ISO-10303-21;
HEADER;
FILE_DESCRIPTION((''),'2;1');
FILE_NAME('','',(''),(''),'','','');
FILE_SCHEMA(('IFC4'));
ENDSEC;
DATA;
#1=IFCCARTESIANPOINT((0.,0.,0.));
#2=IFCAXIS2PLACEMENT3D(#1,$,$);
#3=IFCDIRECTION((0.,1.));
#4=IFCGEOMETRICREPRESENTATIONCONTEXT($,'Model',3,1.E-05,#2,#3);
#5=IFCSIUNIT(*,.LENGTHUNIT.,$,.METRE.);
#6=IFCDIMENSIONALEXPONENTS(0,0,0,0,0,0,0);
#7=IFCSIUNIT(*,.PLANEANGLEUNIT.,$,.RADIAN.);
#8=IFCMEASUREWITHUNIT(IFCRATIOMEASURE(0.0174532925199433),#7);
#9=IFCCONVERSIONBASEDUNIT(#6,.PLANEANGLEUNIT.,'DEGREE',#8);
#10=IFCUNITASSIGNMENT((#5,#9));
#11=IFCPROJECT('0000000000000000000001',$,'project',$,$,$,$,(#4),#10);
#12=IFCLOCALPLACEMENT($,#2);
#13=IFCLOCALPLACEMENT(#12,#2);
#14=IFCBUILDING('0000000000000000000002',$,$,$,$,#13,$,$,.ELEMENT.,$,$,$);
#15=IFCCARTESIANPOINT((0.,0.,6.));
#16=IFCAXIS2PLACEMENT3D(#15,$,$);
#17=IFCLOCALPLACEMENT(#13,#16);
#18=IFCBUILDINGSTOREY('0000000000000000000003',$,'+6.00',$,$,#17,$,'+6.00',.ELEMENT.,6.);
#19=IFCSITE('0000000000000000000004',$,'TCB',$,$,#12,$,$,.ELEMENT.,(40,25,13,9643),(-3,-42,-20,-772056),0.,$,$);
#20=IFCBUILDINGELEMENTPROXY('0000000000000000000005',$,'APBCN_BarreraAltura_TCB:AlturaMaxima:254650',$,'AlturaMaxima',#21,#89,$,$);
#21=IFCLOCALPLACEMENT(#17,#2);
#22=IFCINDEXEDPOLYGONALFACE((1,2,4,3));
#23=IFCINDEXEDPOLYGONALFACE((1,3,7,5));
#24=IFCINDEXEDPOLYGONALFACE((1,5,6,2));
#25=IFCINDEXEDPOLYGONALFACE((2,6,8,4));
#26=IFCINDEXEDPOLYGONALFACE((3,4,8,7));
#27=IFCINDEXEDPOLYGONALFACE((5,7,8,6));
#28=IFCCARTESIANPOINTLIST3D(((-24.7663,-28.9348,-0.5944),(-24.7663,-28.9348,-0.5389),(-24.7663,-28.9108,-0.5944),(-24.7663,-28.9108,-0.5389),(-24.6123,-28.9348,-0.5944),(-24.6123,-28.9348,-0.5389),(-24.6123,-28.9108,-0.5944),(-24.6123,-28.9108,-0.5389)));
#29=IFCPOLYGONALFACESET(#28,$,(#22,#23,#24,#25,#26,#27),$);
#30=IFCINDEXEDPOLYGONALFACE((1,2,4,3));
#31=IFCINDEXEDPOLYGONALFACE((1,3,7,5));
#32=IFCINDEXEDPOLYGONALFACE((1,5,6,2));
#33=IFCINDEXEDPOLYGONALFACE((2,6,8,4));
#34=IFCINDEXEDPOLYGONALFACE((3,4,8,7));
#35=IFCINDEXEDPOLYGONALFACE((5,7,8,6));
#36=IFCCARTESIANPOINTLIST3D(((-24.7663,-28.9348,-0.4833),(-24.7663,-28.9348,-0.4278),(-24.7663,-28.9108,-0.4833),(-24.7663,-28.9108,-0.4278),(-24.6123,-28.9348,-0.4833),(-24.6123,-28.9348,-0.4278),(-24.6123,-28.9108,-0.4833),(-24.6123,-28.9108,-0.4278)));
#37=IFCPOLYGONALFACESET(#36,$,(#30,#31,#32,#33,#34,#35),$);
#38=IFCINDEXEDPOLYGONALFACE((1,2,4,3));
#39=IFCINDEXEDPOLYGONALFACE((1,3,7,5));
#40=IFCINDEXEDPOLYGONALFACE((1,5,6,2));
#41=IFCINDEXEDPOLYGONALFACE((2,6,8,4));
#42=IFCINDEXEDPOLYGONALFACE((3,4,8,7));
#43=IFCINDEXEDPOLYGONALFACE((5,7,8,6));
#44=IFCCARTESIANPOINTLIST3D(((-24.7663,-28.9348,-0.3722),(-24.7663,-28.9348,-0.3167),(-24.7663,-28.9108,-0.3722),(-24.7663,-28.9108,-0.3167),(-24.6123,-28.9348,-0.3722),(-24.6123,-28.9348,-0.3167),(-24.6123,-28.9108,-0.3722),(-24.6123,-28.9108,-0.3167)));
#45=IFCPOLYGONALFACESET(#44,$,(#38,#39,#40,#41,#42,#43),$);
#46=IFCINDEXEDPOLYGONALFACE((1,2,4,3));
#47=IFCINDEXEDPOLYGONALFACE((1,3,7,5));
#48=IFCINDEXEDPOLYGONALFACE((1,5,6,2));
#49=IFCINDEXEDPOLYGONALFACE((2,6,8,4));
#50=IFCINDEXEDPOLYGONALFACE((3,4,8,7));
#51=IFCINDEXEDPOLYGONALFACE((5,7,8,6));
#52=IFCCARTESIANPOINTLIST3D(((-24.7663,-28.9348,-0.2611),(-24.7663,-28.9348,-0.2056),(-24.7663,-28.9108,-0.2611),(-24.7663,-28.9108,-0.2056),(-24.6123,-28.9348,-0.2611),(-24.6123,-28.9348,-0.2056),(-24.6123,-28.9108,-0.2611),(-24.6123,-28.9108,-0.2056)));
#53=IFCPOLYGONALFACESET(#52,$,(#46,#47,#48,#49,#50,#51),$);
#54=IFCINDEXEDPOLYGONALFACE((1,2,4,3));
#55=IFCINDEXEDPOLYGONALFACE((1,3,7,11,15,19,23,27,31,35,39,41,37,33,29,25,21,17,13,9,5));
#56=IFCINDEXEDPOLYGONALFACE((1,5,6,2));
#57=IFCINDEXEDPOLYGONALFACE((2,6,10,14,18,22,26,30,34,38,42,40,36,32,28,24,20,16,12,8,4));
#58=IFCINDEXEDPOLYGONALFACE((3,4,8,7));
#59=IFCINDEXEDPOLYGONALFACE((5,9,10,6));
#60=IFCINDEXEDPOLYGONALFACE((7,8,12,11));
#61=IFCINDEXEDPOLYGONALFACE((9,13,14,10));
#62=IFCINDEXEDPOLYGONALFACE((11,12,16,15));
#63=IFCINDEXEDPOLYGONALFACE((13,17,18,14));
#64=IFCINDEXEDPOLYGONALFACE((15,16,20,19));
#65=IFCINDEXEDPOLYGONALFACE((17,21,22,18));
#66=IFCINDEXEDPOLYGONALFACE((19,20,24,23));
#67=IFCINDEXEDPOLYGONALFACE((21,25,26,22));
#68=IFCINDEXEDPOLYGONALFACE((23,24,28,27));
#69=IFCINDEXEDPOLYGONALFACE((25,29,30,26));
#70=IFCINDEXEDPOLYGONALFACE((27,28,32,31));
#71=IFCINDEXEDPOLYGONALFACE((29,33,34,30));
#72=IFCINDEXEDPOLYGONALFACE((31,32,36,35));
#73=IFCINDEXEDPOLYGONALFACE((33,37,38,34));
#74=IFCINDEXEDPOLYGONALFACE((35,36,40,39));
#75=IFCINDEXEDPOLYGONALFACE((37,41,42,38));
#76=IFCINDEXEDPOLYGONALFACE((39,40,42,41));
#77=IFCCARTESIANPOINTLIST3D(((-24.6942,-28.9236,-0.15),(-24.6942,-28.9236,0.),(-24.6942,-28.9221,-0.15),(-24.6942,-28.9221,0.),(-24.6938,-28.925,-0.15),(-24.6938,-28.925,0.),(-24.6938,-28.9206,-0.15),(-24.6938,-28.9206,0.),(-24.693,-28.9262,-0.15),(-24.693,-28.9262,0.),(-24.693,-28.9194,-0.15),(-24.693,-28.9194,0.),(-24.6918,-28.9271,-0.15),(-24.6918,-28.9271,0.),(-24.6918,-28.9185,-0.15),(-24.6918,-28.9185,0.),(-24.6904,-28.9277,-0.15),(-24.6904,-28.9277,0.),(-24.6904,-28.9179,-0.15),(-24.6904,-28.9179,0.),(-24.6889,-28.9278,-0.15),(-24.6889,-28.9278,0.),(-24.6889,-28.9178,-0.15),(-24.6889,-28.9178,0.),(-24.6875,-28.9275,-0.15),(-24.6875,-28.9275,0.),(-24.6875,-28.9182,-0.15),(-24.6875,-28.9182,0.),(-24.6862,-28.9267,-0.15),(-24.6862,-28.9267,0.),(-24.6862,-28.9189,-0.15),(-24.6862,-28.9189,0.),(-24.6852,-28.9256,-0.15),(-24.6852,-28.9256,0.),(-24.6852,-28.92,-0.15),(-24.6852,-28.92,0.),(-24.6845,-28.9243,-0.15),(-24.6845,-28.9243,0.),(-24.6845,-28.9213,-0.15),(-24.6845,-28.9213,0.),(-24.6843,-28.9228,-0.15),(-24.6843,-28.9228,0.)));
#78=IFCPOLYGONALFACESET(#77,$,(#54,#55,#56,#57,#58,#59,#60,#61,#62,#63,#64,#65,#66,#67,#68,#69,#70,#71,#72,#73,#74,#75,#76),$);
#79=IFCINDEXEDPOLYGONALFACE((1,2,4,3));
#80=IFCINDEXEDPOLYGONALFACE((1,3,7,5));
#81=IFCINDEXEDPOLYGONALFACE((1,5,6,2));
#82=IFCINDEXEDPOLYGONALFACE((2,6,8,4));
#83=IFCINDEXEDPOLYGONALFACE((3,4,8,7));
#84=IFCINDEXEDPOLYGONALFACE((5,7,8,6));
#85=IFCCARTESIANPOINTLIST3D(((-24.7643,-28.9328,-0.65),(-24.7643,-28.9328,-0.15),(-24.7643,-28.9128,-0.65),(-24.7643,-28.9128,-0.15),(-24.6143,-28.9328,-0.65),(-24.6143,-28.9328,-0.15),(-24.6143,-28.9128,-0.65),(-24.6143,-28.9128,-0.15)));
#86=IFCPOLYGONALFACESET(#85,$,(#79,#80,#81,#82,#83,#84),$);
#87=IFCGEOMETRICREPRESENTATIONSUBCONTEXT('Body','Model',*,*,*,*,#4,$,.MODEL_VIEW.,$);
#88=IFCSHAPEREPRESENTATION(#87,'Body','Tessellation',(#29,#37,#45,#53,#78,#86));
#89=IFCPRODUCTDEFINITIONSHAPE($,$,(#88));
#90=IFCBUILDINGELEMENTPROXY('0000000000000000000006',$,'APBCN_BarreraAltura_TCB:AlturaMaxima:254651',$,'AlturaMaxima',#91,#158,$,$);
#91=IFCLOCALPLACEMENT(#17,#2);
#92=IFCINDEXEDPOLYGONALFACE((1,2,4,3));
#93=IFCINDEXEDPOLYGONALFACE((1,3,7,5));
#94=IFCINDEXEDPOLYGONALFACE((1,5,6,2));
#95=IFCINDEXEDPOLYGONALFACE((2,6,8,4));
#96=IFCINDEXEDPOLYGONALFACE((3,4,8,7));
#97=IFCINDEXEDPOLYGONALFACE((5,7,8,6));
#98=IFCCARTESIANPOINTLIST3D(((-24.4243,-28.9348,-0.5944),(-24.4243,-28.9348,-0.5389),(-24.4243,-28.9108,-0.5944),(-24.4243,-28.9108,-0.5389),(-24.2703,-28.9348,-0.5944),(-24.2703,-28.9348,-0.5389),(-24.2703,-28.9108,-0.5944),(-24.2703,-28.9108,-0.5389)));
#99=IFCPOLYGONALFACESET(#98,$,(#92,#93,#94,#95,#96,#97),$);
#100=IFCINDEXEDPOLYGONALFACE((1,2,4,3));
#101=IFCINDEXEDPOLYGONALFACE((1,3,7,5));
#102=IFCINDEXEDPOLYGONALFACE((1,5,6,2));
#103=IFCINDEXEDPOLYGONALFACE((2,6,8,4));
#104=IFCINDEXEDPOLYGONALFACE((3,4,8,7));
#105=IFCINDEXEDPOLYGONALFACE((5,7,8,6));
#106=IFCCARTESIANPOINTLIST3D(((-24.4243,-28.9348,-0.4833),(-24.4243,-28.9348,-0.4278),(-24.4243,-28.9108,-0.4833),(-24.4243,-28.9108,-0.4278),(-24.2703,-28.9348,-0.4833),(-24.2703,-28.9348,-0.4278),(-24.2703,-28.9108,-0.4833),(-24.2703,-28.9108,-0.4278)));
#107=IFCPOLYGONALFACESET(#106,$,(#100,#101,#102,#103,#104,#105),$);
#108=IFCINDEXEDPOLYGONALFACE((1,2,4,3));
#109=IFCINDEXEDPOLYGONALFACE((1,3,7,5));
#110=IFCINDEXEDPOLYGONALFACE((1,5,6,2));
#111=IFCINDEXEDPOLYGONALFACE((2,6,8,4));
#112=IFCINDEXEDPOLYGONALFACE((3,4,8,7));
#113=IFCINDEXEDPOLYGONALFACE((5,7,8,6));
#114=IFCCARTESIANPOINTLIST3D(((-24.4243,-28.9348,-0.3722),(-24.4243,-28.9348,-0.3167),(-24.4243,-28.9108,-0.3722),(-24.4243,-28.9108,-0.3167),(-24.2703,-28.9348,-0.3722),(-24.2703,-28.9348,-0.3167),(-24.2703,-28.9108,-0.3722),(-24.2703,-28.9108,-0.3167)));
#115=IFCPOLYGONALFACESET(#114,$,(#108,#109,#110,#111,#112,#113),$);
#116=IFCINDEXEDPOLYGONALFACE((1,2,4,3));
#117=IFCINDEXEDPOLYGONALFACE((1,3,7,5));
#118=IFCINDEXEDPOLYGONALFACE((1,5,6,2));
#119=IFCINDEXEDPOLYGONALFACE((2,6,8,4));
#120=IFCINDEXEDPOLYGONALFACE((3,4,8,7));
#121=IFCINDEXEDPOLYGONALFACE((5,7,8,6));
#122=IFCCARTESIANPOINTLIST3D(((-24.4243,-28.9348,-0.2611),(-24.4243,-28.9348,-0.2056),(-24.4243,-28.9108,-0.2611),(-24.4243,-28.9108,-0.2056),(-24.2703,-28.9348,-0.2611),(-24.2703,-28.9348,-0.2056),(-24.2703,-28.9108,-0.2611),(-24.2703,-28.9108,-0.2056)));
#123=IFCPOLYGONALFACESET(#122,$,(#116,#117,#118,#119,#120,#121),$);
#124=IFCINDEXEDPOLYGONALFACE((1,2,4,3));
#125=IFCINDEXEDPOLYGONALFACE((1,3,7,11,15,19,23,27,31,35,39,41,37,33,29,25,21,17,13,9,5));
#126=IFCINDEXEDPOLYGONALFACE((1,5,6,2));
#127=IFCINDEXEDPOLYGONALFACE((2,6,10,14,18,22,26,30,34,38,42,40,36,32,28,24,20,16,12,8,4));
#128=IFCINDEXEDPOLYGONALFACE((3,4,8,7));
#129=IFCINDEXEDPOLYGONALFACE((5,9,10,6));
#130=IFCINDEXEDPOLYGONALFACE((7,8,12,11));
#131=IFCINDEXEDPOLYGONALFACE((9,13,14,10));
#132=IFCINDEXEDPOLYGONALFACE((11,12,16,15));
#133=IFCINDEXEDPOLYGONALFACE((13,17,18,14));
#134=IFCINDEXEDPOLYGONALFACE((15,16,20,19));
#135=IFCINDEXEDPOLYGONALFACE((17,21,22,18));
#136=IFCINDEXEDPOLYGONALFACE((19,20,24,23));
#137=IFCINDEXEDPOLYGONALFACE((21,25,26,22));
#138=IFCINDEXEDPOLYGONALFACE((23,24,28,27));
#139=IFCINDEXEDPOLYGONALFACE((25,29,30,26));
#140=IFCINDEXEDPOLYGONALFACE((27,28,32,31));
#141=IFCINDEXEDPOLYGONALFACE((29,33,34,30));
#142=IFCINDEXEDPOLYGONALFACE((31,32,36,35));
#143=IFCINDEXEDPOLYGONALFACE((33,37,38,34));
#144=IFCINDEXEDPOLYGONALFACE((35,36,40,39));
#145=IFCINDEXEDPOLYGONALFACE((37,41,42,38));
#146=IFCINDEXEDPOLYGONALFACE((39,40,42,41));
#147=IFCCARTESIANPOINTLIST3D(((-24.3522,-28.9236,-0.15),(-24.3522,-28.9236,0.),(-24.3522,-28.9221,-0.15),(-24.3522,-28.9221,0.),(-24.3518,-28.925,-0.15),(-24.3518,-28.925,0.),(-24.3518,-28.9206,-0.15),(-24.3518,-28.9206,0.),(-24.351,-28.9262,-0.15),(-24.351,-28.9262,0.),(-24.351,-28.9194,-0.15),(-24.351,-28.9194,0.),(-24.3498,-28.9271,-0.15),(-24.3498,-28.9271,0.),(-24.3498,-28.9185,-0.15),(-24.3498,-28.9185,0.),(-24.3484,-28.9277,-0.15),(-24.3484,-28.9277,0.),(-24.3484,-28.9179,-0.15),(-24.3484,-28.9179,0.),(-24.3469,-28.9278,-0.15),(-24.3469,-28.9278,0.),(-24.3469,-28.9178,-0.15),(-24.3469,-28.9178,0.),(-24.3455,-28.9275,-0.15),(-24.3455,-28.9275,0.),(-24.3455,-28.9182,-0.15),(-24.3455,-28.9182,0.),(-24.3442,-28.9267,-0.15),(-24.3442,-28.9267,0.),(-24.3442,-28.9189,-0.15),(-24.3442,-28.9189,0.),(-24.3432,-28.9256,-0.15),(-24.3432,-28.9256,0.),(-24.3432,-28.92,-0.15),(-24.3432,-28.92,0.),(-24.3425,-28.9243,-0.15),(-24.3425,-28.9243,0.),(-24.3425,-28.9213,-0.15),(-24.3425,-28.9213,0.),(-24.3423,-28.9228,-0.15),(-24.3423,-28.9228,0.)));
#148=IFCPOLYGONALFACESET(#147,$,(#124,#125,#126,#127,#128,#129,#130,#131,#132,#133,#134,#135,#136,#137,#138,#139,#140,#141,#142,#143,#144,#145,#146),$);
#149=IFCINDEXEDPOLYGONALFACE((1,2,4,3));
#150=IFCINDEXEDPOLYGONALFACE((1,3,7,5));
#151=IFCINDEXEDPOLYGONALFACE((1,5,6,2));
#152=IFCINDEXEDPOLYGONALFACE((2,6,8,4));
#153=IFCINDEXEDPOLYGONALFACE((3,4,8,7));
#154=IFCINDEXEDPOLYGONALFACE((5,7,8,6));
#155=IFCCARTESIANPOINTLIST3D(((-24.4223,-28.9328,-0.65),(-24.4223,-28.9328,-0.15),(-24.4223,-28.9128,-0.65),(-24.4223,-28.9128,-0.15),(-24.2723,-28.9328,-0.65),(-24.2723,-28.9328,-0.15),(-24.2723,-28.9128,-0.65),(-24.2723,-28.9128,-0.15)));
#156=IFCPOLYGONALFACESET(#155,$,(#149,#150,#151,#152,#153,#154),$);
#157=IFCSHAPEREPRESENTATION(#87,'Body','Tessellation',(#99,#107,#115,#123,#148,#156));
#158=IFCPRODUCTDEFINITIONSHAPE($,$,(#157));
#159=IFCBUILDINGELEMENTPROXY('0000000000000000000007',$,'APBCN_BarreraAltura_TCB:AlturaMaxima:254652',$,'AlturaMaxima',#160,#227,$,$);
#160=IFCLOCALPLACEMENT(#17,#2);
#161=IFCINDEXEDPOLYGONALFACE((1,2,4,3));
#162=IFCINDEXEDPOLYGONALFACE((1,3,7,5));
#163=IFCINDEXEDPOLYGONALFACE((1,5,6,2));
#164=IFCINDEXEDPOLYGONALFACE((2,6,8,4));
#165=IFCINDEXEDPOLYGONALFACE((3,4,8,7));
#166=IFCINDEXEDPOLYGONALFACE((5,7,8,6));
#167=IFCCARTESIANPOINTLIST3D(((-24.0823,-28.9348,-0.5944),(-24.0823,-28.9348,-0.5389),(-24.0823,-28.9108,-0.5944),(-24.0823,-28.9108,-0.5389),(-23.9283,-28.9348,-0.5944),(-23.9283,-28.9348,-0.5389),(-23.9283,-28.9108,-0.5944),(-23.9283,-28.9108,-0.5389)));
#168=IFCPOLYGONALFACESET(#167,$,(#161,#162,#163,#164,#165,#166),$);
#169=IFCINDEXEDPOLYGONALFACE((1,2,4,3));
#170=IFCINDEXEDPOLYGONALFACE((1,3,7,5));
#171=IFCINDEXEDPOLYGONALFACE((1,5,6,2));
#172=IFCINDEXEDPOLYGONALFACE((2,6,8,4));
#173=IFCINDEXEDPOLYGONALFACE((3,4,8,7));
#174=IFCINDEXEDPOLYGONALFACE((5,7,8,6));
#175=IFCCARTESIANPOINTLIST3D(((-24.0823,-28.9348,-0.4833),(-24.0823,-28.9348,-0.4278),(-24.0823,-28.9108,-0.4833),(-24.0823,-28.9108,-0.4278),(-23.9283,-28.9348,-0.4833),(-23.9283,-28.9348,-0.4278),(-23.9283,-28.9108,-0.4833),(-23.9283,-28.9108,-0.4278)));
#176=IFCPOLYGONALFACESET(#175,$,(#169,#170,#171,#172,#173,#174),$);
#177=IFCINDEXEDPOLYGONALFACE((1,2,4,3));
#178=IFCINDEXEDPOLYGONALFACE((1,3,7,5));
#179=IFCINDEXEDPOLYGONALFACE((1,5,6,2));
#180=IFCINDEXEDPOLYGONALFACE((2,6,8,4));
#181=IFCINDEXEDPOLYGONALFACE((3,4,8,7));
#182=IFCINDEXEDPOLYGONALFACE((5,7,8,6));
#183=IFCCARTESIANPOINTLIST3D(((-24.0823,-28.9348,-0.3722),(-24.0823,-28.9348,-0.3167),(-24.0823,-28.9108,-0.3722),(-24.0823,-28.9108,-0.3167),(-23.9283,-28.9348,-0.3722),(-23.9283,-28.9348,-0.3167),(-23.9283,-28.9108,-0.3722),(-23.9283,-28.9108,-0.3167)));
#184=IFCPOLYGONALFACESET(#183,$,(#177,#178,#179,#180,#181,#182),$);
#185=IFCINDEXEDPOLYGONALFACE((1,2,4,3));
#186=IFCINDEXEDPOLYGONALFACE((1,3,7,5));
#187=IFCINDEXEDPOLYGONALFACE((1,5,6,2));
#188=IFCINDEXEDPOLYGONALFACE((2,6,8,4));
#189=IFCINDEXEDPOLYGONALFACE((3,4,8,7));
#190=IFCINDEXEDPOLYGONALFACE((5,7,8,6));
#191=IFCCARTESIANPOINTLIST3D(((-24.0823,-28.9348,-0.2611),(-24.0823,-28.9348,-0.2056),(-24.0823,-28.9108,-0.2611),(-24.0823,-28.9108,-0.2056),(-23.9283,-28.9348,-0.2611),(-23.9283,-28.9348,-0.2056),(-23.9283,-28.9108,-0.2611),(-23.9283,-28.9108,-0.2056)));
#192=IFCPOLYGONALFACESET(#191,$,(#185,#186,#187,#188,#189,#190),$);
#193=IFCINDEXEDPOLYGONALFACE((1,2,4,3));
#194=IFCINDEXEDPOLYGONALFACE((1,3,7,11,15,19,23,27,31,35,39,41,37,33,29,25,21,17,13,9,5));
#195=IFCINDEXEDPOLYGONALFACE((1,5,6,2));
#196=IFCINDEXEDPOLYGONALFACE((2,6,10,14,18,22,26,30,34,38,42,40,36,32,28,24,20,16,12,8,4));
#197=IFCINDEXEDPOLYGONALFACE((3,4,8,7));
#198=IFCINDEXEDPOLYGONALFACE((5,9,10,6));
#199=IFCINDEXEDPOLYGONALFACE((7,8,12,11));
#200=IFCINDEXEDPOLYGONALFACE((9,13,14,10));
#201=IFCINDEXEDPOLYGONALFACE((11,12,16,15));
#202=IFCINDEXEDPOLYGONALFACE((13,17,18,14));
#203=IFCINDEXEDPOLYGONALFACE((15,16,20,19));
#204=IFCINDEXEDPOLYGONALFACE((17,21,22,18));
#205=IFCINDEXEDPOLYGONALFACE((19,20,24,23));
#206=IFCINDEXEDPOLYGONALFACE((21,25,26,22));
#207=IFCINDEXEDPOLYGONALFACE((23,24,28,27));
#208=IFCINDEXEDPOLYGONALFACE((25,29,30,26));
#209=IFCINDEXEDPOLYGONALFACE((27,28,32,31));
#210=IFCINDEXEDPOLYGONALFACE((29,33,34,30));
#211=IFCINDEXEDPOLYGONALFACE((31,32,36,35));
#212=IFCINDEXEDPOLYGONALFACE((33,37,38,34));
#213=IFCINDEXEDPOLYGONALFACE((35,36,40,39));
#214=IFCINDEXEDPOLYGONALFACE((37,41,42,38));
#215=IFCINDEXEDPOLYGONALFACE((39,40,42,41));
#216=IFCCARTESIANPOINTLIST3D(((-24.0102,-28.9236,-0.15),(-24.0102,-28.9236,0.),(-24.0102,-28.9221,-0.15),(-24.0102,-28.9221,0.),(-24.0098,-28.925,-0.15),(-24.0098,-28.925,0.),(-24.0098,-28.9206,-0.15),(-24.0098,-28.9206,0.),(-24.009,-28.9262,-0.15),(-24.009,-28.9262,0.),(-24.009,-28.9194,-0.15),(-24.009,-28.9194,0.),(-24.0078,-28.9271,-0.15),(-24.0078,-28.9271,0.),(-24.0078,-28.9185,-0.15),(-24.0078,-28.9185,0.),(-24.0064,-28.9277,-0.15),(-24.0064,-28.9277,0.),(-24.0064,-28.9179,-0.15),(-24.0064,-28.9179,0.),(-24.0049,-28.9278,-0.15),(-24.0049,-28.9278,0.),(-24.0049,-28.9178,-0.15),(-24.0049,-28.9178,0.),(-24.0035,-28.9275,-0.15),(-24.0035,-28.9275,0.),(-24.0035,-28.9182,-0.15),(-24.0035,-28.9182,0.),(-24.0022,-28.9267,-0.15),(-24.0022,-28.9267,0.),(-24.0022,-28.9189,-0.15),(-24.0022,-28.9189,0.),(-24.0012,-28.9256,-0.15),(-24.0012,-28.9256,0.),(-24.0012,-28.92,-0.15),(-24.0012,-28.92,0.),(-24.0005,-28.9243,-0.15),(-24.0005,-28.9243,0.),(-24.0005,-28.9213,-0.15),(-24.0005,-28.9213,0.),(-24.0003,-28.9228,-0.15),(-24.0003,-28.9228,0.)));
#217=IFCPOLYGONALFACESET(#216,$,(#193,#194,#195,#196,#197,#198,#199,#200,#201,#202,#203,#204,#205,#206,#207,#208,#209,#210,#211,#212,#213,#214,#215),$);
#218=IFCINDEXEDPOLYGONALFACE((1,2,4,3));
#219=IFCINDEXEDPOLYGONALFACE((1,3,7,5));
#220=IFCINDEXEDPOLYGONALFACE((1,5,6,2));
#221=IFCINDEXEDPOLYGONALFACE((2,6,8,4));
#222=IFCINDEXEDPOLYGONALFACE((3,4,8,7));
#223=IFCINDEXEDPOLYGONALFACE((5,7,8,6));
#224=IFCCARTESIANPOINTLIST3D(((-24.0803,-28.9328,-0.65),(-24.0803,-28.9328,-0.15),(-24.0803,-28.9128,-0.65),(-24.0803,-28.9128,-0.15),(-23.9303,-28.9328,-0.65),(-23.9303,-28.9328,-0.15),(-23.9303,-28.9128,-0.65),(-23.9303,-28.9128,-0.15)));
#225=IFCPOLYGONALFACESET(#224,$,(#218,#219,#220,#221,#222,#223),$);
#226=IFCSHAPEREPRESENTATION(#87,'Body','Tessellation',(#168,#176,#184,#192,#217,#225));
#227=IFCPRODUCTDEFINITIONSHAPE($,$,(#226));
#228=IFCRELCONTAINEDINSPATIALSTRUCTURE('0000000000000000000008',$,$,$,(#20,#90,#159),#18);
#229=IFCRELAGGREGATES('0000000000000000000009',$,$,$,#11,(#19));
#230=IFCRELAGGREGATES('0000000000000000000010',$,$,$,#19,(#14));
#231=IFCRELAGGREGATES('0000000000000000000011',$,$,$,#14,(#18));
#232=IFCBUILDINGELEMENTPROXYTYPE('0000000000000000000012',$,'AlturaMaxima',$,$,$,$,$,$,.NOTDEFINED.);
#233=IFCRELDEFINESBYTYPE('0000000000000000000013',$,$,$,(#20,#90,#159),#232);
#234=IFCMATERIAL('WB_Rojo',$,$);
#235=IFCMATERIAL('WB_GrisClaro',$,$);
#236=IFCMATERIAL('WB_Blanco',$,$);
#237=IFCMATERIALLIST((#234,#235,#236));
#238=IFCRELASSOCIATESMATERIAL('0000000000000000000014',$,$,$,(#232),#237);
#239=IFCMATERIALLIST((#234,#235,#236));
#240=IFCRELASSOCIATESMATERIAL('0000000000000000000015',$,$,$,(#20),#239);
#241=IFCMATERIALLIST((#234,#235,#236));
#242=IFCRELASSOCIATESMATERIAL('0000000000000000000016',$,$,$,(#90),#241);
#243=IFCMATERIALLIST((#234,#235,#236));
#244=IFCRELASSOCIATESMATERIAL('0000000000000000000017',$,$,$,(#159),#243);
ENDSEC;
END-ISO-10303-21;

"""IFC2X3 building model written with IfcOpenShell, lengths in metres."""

from ifc_helpers import new_model, entity, si_unit, converted_unit, direction, frame, frame_2d, origin, origin_2d_with_axis, place, context, subcontext, project, spatial, rectangle, circle, extrude, source, transform, mapped, material, material_list, type_object, type_shapes, element, save


model = new_model("IFC2X3")

# Units and contexts
model_context = context("Model", 3, precision=1e-05, world=origin(), true_north=direction((0.0, 1.0)))
body_context = subcontext(model_context, "Body", "Model", "MODEL_VIEW")
ifc_project = project(units=[si_unit("LENGTHUNIT", "METRE"), converted_unit("PLANEANGLEUNIT", "DEGREE", entity("IfcRatioMeasure", 0.0174532925199433), si_unit("PLANEANGLEUNIT", "RADIAN"), dimensions=[0, 0, 0, 0, 0, 0, 0])], contexts=[model_context])

# Site, building, storey
site_placement = place(None, origin())
site = spatial("IfcSite", under=ifc_project, at=site_placement, Name="TCB", CompositionType="ELEMENT", RefLatitude=(40, 25, 13, 9643), RefLongitude=(-3, -42, -20, -772056), RefElevation=0.0)
building_placement = place(site_placement, origin())
building = spatial("IfcBuilding", under=site, at=building_placement, CompositionType="ELEMENT")
storey_placement = place(building_placement, frame((0.0, 0.0, 6.0)))
storey = spatial("IfcBuildingStorey", under=building, at=storey_placement, Name="+6.00", LongName="+6.00", CompositionType="ELEMENT", Elevation=6.0)

# Building element proxies
ifc_material_1 = material(Name="WB_Rojo")
ifc_material_2 = material(Name="WB_GrisClaro")
ifc_material_3 = material(Name="WB_Blanco")
ifc_material_list_1 = material_list([ifc_material_1, ifc_material_2, ifc_material_3])
building_element_proxy_type = type_object("IfcBuildingElementProxyType", Name="AlturaMaxima", PredefinedType="NOTDEFINED", material=ifc_material_list_1)
shared_shape = source(origin(), body_context, "Body", "SweptSolid", [
    extrude(rectangle(XDim=0.154, YDim=0.024, at=frame_2d((0.0, 0.0), x_axis=(1.0, 0.0))), frame((0.0, 0.0, -0.5944), z_axis=(0.0, 0.0, 1.0), x_axis=(-1.0, 0.0, 0.0)), (0.0, 0.0, 1.0), 0.0556),
    extrude(rectangle(XDim=0.154, YDim=0.024, at=frame_2d((0.0, 0.0), x_axis=(1.0, 0.0))), frame((0.0, 0.0, -0.4833), z_axis=(0.0, 0.0, 1.0), x_axis=(-1.0, 0.0, 0.0)), (0.0, 0.0, 1.0), 0.0556),
    extrude(rectangle(XDim=0.154, YDim=0.024, at=frame_2d((0.0, 0.0), x_axis=(1.0, 0.0))), frame((0.0, 0.0, -0.3722), z_axis=(0.0, 0.0, 1.0), x_axis=(-1.0, 0.0, 0.0)), (0.0, 0.0, 1.0), 0.0556),
    extrude(rectangle(XDim=0.154, YDim=0.024, at=frame_2d((0.0, 0.0), x_axis=(1.0, 0.0))), frame((0.0, 0.0, -0.2611), z_axis=(0.0, 0.0, 1.0), x_axis=(-1.0, 0.0, 0.0)), (0.0, 0.0, 1.0), 0.0556),
    extrude(circle(Radius=0.005, at=frame_2d((0.0, 0.0), x_axis=(1.0, 0.0))), frame((0.0, 0.0, -0.15)), (0.0, 0.0, 1.0), 0.15),
    extrude(rectangle(XDim=0.02, YDim=0.15, at=origin_2d_with_axis()), frame((0.0, 0.0, -0.65), z_axis=(0.0, 0.0, 1.0), x_axis=(0.0, 1.0, 0.0)), (0.0, 0.0, 1.0), 0.5),
])
type_shapes(building_element_proxy_type, [shared_shape])
ifc_material_list_2 = material_list([ifc_material_1, ifc_material_2, ifc_material_3])
proxy_1_placement = place(storey_placement, frame((-24.6893, -28.9228, 0.0)))
element("IfcBuildingElementProxy", 1, at=proxy_1_placement, inside=storey, type_object=building_element_proxy_type, material=ifc_material_list_2, Name="APBCN_BarreraAltura_TCB:AlturaMaxima:254650", ObjectType="AlturaMaxima", context=body_context, shape_type="MappedRepresentation", body=[
    mapped(shared_shape, transform((0.0, 0.0, 0.0), scale=1.0)),
])
ifc_material_list_3 = material_list([ifc_material_1, ifc_material_2, ifc_material_3])
proxy_2_placement = place(storey_placement, frame((-24.3473, -28.9228, 0.0)))
element("IfcBuildingElementProxy", 2, at=proxy_2_placement, inside=storey, type_object=building_element_proxy_type, material=ifc_material_list_3, Name="APBCN_BarreraAltura_TCB:AlturaMaxima:254651", ObjectType="AlturaMaxima", context=body_context, shape_type="MappedRepresentation", body=[
    mapped(shared_shape, transform((0.0, 0.0, 0.0), scale=1.0)),
])
ifc_material_list_4 = material_list([ifc_material_1, ifc_material_2, ifc_material_3])
proxy_3_placement = place(storey_placement, frame((-24.0053, -28.9228, 0.0)))
element("IfcBuildingElementProxy", 3, at=proxy_3_placement, inside=storey, type_object=building_element_proxy_type, material=ifc_material_list_4, Name="APBCN_BarreraAltura_TCB:AlturaMaxima:254652", ObjectType="AlturaMaxima", context=body_context, shape_type="MappedRepresentation", body=[
    mapped(shared_shape, transform((0.0, 0.0, 0.0), scale=1.0)),
])

save(model, "model.ifc")
